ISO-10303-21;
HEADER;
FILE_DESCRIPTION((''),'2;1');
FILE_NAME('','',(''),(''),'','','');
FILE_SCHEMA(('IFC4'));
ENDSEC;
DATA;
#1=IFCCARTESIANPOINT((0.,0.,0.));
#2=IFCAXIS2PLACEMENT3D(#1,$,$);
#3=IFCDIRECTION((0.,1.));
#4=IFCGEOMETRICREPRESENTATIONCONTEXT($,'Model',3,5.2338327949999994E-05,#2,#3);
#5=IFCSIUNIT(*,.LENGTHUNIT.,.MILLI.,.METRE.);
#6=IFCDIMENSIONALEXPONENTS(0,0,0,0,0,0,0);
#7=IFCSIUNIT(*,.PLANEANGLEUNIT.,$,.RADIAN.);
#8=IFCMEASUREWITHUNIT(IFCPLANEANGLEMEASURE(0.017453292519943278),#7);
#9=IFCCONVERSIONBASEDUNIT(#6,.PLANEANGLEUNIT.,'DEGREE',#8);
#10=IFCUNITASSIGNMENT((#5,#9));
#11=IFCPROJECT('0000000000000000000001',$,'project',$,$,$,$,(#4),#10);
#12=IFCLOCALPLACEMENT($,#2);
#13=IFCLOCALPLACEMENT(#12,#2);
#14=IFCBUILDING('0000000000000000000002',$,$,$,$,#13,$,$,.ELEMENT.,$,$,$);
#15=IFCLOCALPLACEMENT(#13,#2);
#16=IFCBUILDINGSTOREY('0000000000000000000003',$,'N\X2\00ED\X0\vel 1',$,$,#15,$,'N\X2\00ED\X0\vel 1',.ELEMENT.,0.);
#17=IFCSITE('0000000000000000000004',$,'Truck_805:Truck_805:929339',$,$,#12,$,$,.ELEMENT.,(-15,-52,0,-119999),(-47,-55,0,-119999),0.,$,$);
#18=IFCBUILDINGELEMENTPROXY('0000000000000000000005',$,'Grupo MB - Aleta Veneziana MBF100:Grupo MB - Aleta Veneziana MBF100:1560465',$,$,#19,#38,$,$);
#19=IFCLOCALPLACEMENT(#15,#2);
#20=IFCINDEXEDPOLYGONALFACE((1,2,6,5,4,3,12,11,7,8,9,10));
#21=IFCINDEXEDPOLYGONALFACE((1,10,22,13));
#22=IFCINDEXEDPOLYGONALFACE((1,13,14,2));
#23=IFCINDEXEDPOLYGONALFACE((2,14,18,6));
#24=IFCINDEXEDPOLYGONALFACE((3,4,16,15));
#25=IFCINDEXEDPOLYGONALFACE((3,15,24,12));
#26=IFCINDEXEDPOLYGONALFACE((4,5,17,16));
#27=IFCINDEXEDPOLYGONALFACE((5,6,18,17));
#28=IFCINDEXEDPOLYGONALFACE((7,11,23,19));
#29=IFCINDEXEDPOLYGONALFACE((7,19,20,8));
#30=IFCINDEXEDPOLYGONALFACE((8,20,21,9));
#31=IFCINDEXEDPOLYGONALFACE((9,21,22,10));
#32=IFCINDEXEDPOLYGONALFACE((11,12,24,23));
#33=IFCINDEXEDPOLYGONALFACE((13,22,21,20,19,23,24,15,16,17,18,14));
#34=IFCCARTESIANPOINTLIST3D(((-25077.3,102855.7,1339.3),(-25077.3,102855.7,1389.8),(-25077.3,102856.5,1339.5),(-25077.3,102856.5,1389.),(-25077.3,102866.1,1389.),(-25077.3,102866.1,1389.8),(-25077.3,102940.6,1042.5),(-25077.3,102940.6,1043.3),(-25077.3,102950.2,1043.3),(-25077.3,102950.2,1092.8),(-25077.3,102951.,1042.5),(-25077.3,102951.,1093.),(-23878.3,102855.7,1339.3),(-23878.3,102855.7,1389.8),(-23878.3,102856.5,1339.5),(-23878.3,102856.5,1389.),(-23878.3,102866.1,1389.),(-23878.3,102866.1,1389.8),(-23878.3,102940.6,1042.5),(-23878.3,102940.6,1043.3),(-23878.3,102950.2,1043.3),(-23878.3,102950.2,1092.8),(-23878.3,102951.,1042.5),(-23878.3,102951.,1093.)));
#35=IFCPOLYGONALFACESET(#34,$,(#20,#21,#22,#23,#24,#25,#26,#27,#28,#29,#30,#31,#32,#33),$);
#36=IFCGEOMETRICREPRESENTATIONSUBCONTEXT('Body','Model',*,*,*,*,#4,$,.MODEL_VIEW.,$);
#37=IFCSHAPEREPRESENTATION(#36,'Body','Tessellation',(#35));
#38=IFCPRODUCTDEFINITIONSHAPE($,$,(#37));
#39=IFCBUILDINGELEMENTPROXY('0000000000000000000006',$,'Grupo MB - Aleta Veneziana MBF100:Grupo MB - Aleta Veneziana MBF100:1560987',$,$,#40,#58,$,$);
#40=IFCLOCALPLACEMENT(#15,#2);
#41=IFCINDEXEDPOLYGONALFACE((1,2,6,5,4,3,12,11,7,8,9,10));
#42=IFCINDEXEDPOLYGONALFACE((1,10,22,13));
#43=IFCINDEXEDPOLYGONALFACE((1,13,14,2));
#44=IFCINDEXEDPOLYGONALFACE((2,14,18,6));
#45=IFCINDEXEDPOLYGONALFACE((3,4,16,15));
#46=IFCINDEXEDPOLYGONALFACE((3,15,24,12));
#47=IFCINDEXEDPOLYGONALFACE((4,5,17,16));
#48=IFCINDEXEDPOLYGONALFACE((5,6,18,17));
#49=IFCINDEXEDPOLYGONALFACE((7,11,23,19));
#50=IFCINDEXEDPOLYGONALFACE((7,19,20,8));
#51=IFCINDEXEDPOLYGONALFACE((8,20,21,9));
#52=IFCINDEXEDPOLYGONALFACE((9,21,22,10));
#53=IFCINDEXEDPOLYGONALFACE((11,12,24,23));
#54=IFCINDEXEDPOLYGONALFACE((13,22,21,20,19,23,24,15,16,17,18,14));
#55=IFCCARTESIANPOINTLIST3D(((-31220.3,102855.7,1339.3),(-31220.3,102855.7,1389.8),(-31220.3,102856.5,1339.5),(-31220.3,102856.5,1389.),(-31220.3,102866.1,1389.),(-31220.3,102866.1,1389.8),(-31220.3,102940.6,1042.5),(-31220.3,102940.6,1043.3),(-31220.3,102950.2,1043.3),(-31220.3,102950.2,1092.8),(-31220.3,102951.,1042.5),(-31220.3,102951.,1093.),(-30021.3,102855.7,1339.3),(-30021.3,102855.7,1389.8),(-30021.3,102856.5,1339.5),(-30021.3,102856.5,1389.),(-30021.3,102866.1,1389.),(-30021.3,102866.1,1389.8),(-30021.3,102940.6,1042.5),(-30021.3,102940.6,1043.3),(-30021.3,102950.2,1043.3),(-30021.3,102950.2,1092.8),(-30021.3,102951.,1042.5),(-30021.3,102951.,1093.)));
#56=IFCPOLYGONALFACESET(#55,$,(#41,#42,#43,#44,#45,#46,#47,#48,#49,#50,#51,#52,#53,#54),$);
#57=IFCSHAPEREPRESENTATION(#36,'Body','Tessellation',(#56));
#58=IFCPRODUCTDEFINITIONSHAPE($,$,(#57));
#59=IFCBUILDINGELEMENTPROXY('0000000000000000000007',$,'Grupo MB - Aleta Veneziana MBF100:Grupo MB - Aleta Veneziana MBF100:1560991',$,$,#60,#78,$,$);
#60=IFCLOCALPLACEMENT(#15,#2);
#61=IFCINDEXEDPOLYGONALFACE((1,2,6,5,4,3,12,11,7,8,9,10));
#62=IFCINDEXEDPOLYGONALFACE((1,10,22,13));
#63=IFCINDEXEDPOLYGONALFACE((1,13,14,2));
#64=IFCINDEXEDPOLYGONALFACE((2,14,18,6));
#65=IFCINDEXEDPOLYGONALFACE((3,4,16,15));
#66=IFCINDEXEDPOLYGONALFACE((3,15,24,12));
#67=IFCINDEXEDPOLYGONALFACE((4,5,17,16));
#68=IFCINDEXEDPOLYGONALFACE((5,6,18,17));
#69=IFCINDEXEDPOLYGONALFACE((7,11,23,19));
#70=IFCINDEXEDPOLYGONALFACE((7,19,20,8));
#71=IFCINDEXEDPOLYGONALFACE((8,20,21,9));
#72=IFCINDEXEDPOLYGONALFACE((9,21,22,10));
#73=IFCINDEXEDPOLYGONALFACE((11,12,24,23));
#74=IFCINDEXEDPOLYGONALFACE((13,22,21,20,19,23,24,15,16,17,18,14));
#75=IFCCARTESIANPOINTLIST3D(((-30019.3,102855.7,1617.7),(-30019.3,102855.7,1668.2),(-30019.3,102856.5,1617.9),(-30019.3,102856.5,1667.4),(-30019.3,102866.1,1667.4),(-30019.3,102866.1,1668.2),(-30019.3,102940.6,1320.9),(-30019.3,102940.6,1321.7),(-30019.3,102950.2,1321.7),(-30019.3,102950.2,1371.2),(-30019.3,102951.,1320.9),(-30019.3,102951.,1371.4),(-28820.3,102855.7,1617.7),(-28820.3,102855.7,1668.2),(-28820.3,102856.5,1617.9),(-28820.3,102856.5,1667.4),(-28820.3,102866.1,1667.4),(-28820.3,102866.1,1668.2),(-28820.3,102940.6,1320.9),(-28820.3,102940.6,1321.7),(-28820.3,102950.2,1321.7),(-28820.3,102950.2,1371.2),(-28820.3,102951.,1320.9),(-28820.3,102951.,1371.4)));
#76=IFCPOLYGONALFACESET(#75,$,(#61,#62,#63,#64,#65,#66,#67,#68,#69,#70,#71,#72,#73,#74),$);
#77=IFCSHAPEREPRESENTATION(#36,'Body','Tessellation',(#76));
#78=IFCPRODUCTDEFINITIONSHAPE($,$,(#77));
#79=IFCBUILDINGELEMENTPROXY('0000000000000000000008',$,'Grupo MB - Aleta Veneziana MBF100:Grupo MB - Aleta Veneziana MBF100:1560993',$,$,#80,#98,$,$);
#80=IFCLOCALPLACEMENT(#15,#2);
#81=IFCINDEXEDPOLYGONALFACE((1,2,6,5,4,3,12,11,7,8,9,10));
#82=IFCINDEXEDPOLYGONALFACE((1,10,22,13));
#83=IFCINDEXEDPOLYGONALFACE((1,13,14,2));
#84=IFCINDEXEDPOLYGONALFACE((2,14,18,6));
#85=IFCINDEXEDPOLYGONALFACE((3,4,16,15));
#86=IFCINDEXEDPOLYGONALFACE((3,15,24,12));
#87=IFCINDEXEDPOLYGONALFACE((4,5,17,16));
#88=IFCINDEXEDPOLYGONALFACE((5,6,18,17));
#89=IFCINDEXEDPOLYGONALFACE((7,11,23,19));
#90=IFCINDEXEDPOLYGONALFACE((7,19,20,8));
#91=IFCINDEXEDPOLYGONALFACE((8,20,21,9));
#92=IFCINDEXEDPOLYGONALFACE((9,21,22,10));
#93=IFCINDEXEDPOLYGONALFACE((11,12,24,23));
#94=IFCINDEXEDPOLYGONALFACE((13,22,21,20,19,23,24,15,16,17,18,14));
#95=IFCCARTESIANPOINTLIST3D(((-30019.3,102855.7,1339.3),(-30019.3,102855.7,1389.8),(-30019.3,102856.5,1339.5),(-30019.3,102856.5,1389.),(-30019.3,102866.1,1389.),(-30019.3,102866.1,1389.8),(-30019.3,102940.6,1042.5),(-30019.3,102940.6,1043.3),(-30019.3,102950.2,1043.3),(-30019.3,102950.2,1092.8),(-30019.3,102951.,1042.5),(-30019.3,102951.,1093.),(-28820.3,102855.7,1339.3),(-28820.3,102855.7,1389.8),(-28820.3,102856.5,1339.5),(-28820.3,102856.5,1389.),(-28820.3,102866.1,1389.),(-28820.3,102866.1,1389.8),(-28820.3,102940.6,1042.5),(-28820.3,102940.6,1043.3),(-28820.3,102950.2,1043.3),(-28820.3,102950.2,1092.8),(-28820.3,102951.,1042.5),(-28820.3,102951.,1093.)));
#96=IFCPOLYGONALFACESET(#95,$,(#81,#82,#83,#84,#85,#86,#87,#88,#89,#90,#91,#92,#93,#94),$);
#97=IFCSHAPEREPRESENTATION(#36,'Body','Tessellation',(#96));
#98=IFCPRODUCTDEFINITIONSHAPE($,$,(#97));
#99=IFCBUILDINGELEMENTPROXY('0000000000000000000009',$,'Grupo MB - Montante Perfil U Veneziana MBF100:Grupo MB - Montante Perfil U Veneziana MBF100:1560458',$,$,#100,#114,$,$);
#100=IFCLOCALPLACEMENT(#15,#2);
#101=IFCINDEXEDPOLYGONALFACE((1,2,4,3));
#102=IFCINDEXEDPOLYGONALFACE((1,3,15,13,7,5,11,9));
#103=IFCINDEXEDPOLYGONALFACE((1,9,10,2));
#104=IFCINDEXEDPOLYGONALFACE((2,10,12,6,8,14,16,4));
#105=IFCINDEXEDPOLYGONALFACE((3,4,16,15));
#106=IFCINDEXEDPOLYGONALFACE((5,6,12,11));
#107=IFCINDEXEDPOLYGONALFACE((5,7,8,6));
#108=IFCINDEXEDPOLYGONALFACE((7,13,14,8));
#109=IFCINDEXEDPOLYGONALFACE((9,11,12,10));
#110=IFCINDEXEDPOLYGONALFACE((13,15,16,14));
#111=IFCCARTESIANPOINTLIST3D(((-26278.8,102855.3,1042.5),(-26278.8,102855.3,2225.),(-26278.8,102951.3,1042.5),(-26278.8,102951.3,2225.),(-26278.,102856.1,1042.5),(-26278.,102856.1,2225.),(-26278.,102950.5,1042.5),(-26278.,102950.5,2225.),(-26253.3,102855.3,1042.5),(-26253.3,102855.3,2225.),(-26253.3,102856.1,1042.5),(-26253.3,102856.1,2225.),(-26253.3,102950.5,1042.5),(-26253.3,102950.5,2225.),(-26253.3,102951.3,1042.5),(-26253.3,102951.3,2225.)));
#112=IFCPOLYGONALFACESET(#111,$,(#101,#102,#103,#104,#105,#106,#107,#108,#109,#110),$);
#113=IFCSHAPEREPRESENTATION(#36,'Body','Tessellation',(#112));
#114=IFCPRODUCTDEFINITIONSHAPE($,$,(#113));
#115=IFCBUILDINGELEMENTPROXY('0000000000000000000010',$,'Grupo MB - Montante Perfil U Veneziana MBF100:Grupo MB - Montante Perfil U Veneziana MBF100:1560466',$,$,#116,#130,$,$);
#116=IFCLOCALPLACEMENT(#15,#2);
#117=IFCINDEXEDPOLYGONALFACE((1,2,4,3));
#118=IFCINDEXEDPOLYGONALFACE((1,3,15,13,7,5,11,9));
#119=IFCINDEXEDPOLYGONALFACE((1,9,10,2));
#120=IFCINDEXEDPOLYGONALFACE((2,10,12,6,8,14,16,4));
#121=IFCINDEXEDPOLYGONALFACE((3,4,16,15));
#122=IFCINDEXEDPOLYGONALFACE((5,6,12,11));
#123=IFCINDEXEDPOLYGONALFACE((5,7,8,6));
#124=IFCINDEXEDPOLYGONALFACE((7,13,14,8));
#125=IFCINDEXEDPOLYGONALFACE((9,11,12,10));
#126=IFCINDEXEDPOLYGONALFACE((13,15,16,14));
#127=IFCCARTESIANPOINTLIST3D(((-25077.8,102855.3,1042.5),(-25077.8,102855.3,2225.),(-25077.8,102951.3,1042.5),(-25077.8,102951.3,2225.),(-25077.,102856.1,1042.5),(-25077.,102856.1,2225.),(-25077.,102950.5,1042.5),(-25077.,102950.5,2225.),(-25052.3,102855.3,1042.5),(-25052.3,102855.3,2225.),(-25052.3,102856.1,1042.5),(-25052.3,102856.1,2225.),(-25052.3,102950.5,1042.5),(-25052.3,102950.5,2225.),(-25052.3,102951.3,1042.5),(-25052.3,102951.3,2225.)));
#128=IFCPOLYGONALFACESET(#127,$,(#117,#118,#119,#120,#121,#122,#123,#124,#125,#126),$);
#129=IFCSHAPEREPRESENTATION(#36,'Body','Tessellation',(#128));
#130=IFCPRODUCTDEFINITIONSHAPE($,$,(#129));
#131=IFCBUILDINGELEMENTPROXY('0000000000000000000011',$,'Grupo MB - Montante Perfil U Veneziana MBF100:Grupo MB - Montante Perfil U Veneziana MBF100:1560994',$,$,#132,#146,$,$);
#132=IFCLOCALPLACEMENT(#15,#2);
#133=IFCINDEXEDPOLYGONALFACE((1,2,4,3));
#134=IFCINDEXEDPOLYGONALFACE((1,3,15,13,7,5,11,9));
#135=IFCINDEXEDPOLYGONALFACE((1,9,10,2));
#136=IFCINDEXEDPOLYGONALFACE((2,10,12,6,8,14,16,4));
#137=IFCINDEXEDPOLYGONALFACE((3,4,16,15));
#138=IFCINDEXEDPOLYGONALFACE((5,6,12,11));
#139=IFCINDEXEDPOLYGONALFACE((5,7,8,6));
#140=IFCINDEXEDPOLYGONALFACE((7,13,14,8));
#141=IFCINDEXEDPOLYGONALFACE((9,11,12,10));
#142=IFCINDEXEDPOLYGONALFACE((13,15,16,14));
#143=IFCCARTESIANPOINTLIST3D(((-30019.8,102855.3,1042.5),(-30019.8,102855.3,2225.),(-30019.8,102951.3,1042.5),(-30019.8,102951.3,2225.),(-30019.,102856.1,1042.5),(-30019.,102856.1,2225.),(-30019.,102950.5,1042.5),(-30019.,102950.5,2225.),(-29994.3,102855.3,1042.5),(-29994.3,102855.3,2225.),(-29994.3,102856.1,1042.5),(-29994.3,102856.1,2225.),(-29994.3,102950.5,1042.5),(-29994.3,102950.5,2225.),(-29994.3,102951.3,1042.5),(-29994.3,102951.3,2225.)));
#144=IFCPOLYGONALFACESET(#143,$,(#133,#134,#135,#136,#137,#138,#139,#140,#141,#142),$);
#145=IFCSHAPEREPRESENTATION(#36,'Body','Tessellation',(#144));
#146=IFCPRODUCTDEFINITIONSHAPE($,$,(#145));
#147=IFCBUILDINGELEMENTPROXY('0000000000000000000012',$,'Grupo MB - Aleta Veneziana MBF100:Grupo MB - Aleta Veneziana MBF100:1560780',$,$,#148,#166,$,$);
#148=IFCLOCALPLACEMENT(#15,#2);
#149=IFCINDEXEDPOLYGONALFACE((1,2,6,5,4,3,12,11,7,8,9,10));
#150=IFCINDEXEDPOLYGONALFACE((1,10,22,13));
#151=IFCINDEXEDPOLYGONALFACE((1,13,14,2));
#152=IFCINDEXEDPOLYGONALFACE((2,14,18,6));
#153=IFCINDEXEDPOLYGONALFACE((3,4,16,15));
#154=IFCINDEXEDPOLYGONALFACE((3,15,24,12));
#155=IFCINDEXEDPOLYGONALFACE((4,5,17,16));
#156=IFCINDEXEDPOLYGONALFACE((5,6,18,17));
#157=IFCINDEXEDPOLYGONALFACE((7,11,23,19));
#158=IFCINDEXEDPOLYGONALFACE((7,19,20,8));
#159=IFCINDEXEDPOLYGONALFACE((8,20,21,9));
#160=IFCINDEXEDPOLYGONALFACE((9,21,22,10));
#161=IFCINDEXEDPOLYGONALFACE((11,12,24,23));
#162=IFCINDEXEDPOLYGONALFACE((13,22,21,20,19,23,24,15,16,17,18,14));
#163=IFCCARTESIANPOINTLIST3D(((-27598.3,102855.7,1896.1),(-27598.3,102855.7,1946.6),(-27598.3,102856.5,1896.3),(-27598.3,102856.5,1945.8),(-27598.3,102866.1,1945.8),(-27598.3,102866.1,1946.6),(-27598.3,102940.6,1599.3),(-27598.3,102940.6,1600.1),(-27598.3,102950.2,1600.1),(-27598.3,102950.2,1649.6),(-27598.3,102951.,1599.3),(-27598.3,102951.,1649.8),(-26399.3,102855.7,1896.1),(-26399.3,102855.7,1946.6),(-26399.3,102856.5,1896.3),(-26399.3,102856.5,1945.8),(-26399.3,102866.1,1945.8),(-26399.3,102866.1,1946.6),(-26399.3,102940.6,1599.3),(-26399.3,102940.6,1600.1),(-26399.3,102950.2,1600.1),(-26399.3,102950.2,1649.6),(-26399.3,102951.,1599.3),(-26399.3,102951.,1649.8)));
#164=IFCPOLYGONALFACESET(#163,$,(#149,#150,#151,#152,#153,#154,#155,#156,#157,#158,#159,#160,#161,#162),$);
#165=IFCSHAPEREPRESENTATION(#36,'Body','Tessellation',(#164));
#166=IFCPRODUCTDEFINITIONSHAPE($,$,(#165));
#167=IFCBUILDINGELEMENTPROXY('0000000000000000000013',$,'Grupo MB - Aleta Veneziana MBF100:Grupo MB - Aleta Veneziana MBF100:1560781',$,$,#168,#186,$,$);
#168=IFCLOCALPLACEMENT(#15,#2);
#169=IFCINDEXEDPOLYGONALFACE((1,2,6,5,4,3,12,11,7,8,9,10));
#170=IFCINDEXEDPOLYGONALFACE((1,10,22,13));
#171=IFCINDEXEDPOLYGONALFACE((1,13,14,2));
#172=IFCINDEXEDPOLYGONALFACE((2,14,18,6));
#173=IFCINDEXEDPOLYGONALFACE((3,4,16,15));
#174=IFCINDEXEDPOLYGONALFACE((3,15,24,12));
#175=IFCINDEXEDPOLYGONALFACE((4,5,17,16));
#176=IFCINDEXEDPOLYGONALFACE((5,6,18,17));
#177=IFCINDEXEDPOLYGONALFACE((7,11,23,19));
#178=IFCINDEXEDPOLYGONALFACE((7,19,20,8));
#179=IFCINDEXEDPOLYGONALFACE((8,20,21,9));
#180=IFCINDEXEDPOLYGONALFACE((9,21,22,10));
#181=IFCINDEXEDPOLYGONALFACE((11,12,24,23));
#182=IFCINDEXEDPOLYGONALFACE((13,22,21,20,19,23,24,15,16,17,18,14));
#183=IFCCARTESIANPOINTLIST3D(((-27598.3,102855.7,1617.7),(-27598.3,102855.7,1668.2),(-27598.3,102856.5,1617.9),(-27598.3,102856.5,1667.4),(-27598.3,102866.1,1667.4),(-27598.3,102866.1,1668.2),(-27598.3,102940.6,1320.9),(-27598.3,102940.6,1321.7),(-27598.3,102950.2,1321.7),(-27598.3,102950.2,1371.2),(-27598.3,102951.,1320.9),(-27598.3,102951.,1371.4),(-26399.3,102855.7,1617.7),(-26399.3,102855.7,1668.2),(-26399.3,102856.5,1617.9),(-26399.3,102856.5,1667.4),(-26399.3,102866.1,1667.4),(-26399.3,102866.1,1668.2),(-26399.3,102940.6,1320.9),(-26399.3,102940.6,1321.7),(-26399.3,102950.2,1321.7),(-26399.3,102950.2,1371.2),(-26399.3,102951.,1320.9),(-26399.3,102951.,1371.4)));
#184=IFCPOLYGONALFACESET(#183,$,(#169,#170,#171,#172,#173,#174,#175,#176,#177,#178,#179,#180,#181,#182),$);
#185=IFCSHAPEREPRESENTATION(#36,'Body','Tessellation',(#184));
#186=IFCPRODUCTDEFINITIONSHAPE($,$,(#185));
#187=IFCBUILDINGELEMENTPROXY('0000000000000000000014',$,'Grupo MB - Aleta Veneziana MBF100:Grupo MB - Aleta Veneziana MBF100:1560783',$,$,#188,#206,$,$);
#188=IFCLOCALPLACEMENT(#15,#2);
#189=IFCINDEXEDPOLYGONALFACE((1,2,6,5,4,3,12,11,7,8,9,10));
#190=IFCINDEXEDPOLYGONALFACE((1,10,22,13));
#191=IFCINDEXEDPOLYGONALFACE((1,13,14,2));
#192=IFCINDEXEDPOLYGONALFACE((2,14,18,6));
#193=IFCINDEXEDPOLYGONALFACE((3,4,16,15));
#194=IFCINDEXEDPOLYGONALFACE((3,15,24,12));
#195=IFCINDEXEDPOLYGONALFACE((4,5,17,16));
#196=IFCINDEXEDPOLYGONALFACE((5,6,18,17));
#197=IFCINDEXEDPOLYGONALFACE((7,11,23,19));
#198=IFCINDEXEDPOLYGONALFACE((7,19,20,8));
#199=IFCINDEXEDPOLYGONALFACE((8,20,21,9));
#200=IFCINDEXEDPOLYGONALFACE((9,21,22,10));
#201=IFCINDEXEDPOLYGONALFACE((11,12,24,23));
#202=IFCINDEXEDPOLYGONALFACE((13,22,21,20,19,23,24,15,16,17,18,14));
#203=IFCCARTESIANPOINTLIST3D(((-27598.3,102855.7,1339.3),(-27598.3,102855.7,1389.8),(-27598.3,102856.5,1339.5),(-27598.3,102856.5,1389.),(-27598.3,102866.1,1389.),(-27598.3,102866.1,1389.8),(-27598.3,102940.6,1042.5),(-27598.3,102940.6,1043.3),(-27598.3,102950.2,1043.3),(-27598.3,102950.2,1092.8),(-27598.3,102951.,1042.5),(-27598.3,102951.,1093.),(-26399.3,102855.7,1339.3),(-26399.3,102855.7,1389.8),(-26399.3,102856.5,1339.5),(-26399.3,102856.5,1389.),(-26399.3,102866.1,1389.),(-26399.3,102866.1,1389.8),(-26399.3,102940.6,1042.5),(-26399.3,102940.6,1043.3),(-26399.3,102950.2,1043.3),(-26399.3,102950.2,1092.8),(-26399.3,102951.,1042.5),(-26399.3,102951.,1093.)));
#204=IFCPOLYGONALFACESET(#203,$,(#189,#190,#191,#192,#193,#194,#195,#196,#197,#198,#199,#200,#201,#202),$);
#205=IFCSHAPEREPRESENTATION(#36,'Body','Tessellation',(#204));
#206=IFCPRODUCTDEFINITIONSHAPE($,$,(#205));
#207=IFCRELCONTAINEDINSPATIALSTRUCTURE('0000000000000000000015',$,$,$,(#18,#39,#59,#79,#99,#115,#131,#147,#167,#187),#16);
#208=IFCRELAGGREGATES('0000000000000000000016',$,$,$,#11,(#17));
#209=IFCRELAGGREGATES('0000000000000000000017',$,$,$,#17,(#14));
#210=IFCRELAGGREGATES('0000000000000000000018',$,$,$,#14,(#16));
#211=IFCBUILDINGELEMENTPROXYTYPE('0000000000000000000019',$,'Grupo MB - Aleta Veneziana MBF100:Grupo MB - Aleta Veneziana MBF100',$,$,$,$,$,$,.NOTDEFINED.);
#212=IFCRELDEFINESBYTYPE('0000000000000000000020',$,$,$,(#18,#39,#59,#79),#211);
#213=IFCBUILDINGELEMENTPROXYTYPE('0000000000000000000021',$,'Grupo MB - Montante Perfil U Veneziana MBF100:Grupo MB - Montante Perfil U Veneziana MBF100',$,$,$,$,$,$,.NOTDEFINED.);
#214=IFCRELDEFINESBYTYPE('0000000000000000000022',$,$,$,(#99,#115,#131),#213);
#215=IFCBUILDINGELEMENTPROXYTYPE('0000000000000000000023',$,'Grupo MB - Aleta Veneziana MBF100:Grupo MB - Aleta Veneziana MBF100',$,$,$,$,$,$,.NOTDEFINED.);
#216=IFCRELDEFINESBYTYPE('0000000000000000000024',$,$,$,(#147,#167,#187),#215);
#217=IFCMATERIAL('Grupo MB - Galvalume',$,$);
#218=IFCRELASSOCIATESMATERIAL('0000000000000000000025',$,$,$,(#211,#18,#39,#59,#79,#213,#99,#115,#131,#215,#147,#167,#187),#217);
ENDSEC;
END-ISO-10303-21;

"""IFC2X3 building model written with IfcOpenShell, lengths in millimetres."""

from ifc_helpers import new_model, entity, si_unit, converted_unit, direction, frame, origin, place, context, subcontext, project, spatial, polyline, outline, extrude, source, transform, mapped, material, type_object, type_shapes, element, save


model = new_model("IFC2X3")

# Units and contexts
model_context = context("Model", 3, precision=5.2338327949999994e-05, world=origin(), true_north=direction((0.0, 1.0)))
body_context = subcontext(model_context, "Body", "Model", "MODEL_VIEW")
ifc_project = project(units=[si_unit("LENGTHUNIT", "METRE", prefix="MILLI"), converted_unit("PLANEANGLEUNIT", "DEGREE", entity("IfcPlaneAngleMeasure", 0.017453292519943278), si_unit("PLANEANGLEUNIT", "RADIAN"), dimensions=[0, 0, 0, 0, 0, 0, 0])], contexts=[model_context])

# Site, building, storey
site_placement = place(None, origin())
site = spatial("IfcSite", under=ifc_project, at=site_placement, Name="Truck_805:Truck_805:929339", CompositionType="ELEMENT", RefLatitude=(-15, -52, 0, -119999), RefLongitude=(-47, -55, 0, -119999), RefElevation=0.0)
building_placement = place(site_placement, origin())
building = spatial("IfcBuilding", under=site, at=building_placement, CompositionType="ELEMENT")
storey_placement = place(building_placement, origin())
storey = spatial("IfcBuildingStorey", under=building, at=storey_placement, Name="Nível 1", LongName="Nível 1", CompositionType="ELEMENT", Elevation=0.0)

# Building element proxies
ifc_material_1 = material(Name="Grupo MB - Galvalume")
building_element_proxy_type_1 = type_object("IfcBuildingElementProxyType", Name="Grupo MB - Aleta Veneziana MBF100:Grupo MB - Aleta Veneziana MBF100", PredefinedType="NOTDEFINED", material=ifc_material_1)
shared_shape_1 = source(origin(), body_context, "Body", "SweptSolid", [
    extrude(outline(polyline([(123.3, -46.8), (-123.2, 47.6), (-173.7, 47.6), (-173.7, 37.2), (-172.9, 37.2), (-172.9, 46.8), (-123.3, 46.8), (123.2, -47.6), (173.7, -47.6), (173.7, -37.2), (172.9, -37.2), (172.9, -46.8), (123.3, -46.8)])), frame((0.0, 47.6, 173.7), z_axis=(-1.0, 0.0, 0.0), x_axis=(0.0, 0.0, -1.0)), (0.0, 0.0, -1.0), 1199.0),
])
type_shapes(building_element_proxy_type_1, [shared_shape_1])
for number, where, name in (
    (1, (-25077.3, 102855.7, 1042.5), "Grupo MB - Aleta Veneziana MBF100:Grupo MB - Aleta Veneziana MBF100:1560465"),
    (2, (-31220.3, 102855.7, 1042.5), "Grupo MB - Aleta Veneziana MBF100:Grupo MB - Aleta Veneziana MBF100:1560987"),
    (3, (-30019.3, 102855.7, 1320.9), "Grupo MB - Aleta Veneziana MBF100:Grupo MB - Aleta Veneziana MBF100:1560991"),
    (4, (-30019.3, 102855.7, 1042.5), "Grupo MB - Aleta Veneziana MBF100:Grupo MB - Aleta Veneziana MBF100:1560993"),
):
    element("IfcBuildingElementProxy", number, at=place(storey_placement, frame(where)), inside=storey, type_object=building_element_proxy_type_1, material=ifc_material_1, Name=name, context=body_context, shape_type="MappedRepresentation", body=[
        mapped(shared_shape_1, transform((0.0, 0.0, 0.0), scale=1.0)),
    ])
building_element_proxy_type_2 = type_object("IfcBuildingElementProxyType", Name="Grupo MB - Montante Perfil U Veneziana MBF100:Grupo MB - Montante Perfil U Veneziana MBF100", PredefinedType="NOTDEFINED", material=ifc_material_1)
shared_shape_2 = source(origin(), body_context, "Body", "SweptSolid", [
    extrude(outline(polyline([(-13.0, -48.0), (12.6, -48.0), (12.6, -47.2), (-12.2, -47.2), (-12.2, 47.2), (12.6, 47.2), (12.6, 48.0), (-13.0, 48.0), (-13.0, -48.0)])), frame((0.0, 48.0, 13.0), z_axis=(1.0, 0.0, 0.0), x_axis=(0.0, 0.0, 1.0)), (0.0, 0.0, 1.0), 1182.5),
])
type_shapes(building_element_proxy_type_2, [shared_shape_2])
for number, where, z_axis, x_axis, name in (
    (5, (-26278.8, 102951.3, 1042.5), (1.0, 0.0, 0.0), (0.0, 0.0, 1.0), "Grupo MB - Montante Perfil U Veneziana MBF100:Grupo MB - Montante Perfil U Veneziana MBF100:1560458"),
    (6, (-25077.8, 102951.3, 1042.5), (1.0, 0.0, 0.0), (0.0, 0.0, 1.0), "Grupo MB - Montante Perfil U Veneziana MBF100:Grupo MB - Montante Perfil U Veneziana MBF100:1560466"),
    (7, (-30019.8, 102951.3, 1042.5), (1.0, 0.0, 0.0), (0.0, 0.0, 1.0), "Grupo MB - Montante Perfil U Veneziana MBF100:Grupo MB - Montante Perfil U Veneziana MBF100:1560994"),
):
    element("IfcBuildingElementProxy", number, at=place(storey_placement, frame(where, z_axis=z_axis, x_axis=x_axis)), inside=storey, type_object=building_element_proxy_type_2, material=ifc_material_1, Name=name, context=body_context, shape_type="MappedRepresentation", body=[
        mapped(shared_shape_2, transform((0.0, 0.0, 0.0), scale=1.0)),
    ])
building_element_proxy_type_3 = type_object("IfcBuildingElementProxyType", Name="Grupo MB - Aleta Veneziana MBF100:Grupo MB - Aleta Veneziana MBF100", PredefinedType="NOTDEFINED", material=ifc_material_1)
shared_shape_3 = source(origin(), body_context, "Body", "SweptSolid", [
    extrude(outline(polyline([(-131.9, -0.4), (132.1, -0.4), (179.2, 17.7), (175.5, 27.4), (174.7, 27.1), (178.2, 18.1), (131.9, 0.4), (-132.1, 0.4), (-179.2, -17.7), (-175.5, -27.4), (-174.7, -27.1), (-178.2, -18.1), (-131.9, -0.4)])), frame((0.0, -47.6, 173.7), z_axis=(1.0, 0.0, 0.0), x_axis=(0.0, 0.357955, 0.933739)), (0.0, 0.0, 1.0), 1199.0),
])
type_shapes(building_element_proxy_type_3, [shared_shape_3])
for number, where, z_axis, x_axis, name in (
    (8, (-26399.3, 102855.7, 1599.3), (0.0, 0.0, 1.0), (-1.0, 0.0, 0.0), "Grupo MB - Aleta Veneziana MBF100:Grupo MB - Aleta Veneziana MBF100:1560780"),
    (9, (-26399.3, 102855.7, 1320.9), (0.0, 0.0, 1.0), (-1.0, 0.0, 0.0), "Grupo MB - Aleta Veneziana MBF100:Grupo MB - Aleta Veneziana MBF100:1560781"),
    (10, (-26399.3, 102855.7, 1042.5), (0.0, 0.0, 1.0), (-1.0, 0.0, 0.0), "Grupo MB - Aleta Veneziana MBF100:Grupo MB - Aleta Veneziana MBF100:1560783"),
):
    element("IfcBuildingElementProxy", number, at=place(storey_placement, frame(where, z_axis=z_axis, x_axis=x_axis)), inside=storey, type_object=building_element_proxy_type_3, material=ifc_material_1, Name=name, context=body_context, shape_type="MappedRepresentation", body=[
        mapped(shared_shape_3, transform((0.0, 0.0, 0.0), scale=1.0)),
    ])

save(model, "model.ifc")
